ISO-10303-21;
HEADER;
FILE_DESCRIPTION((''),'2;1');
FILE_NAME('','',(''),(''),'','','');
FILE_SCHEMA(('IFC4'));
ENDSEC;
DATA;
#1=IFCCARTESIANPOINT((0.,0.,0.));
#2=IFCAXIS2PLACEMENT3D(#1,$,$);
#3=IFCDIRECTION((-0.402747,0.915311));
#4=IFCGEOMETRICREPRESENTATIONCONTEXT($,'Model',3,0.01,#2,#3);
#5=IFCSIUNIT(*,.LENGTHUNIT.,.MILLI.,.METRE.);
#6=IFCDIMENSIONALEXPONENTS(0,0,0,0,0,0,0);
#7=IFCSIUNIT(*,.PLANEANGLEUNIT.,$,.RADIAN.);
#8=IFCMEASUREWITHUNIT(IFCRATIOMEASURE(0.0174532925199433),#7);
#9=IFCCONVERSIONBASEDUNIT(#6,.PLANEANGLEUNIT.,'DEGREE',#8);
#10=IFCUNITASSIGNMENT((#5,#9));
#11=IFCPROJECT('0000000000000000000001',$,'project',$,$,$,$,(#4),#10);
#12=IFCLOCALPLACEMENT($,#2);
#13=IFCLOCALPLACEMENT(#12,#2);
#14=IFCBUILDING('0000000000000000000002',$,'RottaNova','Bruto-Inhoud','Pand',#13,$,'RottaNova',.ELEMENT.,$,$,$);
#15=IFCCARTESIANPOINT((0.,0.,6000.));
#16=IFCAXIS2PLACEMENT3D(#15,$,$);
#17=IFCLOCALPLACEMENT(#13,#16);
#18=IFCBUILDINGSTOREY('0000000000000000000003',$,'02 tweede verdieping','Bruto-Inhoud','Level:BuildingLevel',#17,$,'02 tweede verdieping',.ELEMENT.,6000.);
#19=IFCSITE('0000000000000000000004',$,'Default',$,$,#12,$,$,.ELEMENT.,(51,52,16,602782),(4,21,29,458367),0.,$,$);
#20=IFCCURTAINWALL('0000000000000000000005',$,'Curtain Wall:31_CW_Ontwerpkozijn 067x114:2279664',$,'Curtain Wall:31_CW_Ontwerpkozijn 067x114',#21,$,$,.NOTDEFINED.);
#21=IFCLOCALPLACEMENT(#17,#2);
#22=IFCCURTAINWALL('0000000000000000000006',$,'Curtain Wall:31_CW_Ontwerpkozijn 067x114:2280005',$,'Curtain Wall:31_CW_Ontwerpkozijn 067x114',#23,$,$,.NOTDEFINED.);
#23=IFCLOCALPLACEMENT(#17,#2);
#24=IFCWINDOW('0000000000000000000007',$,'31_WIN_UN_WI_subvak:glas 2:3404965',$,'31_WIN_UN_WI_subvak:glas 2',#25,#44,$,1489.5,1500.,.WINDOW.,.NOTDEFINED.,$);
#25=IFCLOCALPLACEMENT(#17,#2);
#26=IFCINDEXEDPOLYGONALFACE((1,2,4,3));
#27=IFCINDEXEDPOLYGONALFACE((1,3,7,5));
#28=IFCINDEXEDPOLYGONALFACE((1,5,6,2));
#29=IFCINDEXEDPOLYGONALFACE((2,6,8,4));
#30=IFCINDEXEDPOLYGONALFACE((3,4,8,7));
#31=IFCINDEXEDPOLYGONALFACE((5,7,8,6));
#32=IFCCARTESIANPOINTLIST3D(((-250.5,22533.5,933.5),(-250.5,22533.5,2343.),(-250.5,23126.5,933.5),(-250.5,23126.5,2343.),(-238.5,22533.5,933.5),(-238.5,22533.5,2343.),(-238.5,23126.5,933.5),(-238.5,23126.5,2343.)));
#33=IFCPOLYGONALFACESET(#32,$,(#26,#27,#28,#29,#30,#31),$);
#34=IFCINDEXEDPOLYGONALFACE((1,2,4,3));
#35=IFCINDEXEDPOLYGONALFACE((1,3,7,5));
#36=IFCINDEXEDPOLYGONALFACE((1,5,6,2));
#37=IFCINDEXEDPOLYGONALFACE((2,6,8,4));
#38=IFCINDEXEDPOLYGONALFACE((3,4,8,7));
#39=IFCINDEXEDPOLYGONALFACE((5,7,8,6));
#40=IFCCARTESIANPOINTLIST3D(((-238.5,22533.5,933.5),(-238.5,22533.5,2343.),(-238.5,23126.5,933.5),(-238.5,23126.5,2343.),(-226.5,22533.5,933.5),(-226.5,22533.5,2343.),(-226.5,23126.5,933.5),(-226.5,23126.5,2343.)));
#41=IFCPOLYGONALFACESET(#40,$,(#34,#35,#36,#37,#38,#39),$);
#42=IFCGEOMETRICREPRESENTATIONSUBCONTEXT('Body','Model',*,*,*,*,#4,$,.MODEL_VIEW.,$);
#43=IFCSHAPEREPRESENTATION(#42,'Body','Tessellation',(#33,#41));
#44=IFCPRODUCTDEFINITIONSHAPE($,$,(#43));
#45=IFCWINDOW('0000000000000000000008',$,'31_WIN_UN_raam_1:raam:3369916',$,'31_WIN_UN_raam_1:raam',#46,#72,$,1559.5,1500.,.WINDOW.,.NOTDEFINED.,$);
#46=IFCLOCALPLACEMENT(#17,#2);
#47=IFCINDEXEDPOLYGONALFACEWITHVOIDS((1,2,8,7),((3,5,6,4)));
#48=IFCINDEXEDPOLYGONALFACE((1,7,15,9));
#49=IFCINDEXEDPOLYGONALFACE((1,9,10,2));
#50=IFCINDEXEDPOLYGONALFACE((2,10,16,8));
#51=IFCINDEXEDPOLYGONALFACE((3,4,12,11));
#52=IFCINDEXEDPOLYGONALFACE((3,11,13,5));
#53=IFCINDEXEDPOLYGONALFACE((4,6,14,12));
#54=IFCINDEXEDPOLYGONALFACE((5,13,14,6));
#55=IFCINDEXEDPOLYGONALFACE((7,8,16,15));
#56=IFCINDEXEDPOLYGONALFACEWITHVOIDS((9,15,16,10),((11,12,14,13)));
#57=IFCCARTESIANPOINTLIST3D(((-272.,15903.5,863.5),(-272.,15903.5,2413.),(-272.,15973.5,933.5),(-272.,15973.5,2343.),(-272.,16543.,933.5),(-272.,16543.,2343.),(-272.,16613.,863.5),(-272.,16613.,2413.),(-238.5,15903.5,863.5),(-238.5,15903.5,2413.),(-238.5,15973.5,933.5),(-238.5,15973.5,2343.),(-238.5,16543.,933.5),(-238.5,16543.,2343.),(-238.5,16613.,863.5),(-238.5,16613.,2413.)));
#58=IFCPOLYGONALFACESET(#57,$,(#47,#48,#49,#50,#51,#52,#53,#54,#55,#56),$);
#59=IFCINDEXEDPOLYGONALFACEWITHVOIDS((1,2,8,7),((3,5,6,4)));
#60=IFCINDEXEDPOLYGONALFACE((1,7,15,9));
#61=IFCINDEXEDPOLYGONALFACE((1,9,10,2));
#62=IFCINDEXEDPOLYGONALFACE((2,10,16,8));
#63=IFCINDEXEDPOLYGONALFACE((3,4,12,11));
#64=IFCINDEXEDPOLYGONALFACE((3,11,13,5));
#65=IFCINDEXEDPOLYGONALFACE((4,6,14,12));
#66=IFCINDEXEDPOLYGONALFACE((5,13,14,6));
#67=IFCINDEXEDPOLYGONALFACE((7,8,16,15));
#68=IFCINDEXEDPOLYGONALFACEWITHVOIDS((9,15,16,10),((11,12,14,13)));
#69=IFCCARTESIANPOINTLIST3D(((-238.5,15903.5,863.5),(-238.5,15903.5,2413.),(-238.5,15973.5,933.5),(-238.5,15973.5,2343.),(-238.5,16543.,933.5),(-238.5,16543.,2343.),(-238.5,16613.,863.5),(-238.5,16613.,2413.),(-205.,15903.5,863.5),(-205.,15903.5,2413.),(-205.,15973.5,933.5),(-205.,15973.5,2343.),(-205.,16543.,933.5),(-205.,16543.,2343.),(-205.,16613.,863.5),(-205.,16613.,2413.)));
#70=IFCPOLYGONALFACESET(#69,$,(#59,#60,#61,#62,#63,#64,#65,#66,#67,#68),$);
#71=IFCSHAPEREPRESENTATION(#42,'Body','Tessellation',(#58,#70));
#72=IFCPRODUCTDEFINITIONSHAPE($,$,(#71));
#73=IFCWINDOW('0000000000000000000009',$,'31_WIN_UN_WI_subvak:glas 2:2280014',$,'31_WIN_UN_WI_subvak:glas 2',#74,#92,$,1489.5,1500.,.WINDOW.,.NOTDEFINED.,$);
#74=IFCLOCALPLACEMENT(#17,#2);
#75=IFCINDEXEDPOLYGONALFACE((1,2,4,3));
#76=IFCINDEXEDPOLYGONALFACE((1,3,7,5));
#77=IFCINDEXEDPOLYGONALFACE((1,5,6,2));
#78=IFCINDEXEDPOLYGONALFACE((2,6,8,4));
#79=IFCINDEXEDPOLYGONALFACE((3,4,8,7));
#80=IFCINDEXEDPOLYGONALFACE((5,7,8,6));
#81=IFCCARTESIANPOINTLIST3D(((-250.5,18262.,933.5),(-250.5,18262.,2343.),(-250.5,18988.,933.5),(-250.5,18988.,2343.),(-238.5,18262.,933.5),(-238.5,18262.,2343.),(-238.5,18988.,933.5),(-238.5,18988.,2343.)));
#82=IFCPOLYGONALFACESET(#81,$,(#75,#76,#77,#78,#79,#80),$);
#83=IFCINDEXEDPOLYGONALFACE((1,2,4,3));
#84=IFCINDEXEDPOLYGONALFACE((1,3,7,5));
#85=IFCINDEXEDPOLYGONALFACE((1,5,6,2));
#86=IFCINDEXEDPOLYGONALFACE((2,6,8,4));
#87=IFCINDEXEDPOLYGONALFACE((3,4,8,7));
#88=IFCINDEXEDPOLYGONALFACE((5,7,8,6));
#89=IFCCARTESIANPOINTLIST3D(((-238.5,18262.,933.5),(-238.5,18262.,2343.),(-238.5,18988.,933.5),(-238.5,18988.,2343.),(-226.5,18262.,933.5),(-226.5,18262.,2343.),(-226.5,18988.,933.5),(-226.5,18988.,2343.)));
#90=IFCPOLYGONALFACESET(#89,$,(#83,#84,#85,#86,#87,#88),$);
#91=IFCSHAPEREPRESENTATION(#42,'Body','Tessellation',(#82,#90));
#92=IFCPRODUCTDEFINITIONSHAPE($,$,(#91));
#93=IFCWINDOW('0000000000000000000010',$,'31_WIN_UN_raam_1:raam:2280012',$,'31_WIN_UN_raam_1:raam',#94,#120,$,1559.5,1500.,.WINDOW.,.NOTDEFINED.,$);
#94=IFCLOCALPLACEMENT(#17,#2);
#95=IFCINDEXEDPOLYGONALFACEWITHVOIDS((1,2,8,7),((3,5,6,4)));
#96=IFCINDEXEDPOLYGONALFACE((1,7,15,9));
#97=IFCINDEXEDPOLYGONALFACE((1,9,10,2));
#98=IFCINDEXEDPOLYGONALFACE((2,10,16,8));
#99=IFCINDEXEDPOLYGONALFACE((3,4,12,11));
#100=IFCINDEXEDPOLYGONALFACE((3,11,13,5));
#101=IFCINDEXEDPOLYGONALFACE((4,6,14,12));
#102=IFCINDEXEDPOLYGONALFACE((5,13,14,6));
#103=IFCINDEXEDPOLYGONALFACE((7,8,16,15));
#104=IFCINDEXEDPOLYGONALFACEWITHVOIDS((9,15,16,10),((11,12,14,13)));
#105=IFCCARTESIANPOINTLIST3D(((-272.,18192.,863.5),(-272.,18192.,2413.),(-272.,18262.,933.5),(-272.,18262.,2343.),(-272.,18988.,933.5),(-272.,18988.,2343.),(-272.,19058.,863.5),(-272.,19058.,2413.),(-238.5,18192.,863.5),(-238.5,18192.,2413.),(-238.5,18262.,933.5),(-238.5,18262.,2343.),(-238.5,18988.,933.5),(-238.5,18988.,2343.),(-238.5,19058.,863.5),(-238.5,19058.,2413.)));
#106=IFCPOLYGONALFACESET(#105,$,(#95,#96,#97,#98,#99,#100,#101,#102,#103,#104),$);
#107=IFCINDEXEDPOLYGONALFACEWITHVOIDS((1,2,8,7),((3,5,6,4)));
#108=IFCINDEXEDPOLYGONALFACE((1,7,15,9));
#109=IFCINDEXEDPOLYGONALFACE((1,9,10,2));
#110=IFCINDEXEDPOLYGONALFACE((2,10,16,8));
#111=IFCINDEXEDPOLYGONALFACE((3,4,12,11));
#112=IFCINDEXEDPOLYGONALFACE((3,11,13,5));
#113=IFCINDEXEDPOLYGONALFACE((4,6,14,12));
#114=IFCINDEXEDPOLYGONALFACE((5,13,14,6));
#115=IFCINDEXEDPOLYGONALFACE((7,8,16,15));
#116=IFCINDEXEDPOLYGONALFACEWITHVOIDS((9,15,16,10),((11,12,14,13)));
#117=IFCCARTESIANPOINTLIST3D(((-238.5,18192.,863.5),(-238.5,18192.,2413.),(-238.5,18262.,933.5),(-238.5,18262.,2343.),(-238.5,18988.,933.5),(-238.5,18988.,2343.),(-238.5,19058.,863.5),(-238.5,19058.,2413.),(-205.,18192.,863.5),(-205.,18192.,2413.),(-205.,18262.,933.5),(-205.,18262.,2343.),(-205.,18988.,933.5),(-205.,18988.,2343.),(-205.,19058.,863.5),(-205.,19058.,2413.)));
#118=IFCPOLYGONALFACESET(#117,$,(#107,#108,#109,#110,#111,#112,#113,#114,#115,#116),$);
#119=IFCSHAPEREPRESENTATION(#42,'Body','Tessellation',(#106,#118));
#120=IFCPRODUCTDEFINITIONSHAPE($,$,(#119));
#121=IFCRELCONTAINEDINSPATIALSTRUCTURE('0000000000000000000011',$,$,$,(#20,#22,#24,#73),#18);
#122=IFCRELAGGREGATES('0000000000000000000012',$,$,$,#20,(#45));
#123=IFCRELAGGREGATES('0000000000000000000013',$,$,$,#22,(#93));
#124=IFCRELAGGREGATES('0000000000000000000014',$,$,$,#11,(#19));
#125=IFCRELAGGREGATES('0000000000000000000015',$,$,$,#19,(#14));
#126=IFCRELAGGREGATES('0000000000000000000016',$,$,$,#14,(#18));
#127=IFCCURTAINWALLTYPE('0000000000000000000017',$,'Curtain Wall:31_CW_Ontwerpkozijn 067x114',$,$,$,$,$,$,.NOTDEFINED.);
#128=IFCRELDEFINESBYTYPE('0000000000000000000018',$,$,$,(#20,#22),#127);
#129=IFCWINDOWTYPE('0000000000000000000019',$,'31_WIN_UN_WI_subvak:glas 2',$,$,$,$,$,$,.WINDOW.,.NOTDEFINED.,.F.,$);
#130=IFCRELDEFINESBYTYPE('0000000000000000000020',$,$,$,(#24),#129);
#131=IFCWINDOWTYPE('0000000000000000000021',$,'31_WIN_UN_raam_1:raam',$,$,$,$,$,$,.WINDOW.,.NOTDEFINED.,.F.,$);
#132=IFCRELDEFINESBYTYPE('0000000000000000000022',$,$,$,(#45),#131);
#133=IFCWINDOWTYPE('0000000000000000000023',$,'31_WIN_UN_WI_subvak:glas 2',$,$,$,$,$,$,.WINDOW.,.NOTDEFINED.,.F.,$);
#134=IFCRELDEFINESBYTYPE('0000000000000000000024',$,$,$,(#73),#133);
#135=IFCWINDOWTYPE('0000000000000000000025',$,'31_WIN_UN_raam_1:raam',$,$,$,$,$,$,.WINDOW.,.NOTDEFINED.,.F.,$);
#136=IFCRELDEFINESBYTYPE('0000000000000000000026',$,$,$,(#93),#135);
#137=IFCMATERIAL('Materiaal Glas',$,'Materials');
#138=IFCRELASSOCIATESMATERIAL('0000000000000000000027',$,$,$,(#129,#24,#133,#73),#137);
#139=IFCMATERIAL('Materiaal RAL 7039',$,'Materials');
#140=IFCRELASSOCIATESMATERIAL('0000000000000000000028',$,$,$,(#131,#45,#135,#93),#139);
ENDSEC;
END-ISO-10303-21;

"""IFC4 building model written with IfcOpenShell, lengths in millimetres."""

from ifc_helpers import new_model, entity, si_unit, converted_unit, direction, frame, frame_2d, origin, origin_2d_with_axis, place, context, subcontext, project, spatial, polyline, rectangle, outline, extrude, source, transform, mapped, material, type_object, type_shapes, element, aggregate, save


model = new_model("IFC4")

# Units and contexts
model_context = context("Model", 3, precision=0.01, world=origin(), true_north=direction((-0.402747, 0.915311)))
body_context = subcontext(model_context, "Body", "Model", "MODEL_VIEW")
ifc_project = project(units=[si_unit("LENGTHUNIT", "METRE", prefix="MILLI"), converted_unit("PLANEANGLEUNIT", "DEGREE", entity("IfcRatioMeasure", 0.0174532925199433), si_unit("PLANEANGLEUNIT", "RADIAN"), dimensions=[0, 0, 0, 0, 0, 0, 0])], contexts=[model_context])

# Site, building, storey
site_placement = place(None, origin())
site = spatial("IfcSite", under=ifc_project, at=site_placement, Name="Default", CompositionType="ELEMENT", RefLatitude=(51, 52, 16, 602782), RefLongitude=(4, 21, 29, 458367), RefElevation=0.0)
building_placement = place(site_placement, origin())
building = spatial("IfcBuilding", under=site, at=building_placement, Name="RottaNova", Description="Bruto-Inhoud", ObjectType="Pand", LongName="RottaNova", CompositionType="ELEMENT")
storey_placement = place(building_placement, frame((0.0, 0.0, 6000.0)))
storey = spatial("IfcBuildingStorey", under=building, at=storey_placement, Name="02 tweede verdieping", Description="Bruto-Inhoud", ObjectType="Level:BuildingLevel", LongName="02 tweede verdieping", CompositionType="ELEMENT", Elevation=6000.0)

# Curtain walls
curtain_wall_type = type_object("IfcCurtainWallType", Name="Curtain Wall:31_CW_Ontwerpkozijn 067x114", PredefinedType="NOTDEFINED")
curtain_wall_1_placement = place(storey_placement, frame((0.0, 0.0, -6000.0)))
curtain_wall_1 = element("IfcCurtainWall", 1, at=curtain_wall_1_placement, inside=storey, type_object=curtain_wall_type, Name="Curtain Wall:31_CW_Ontwerpkozijn 067x114:2279664", ObjectType="Curtain Wall:31_CW_Ontwerpkozijn 067x114", PredefinedType="NOTDEFINED")
curtain_wall_2_placement = place(storey_placement, frame((0.0, 0.0, -6000.0)))
curtain_wall_2 = element("IfcCurtainWall", 2, at=curtain_wall_2_placement, inside=storey, type_object=curtain_wall_type, Name="Curtain Wall:31_CW_Ontwerpkozijn 067x114:2280005", ObjectType="Curtain Wall:31_CW_Ontwerpkozijn 067x114", PredefinedType="NOTDEFINED")

# Shared definitions
ifc_material_1 = material(Name="Materiaal Glas", Category="Materials")

# Window
window_type_1 = type_object("IfcWindowType", Name="31_WIN_UN_WI_subvak:glas 2", ParameterTakesPrecedence=False, PartitioningType="NOTDEFINED", PredefinedType="WINDOW", material=ifc_material_1)
shared_shape_1 = source(origin(), body_context, "Body", "SweptSolid", [
    extrude(rectangle(XDim=593.0, YDim=12.0, at=origin_2d_with_axis()), frame((0.0, -6.0, 0.0)), (0.0, 0.0, 1.0), 1409.5),
    extrude(rectangle(XDim=593.0, YDim=12.0, at=origin_2d_with_axis()), frame((0.0, 6.0, 0.0)), (0.0, 0.0, 1.0), 1409.5),
])
type_shapes(window_type_1, [shared_shape_1])
window_1_placement = place(storey_placement, frame((-238.5, 22830.0, 933.5), z_axis=(0.0, 0.0, 1.0), x_axis=(0.0, -1.0, 0.0)))
element("IfcWindow", 3, at=window_1_placement, inside=storey, type_object=window_type_1, material=ifc_material_1, Name="31_WIN_UN_WI_subvak:glas 2:3404965", ObjectType="31_WIN_UN_WI_subvak:glas 2", OverallHeight=1489.5, OverallWidth=1500.0, PartitioningType="NOTDEFINED", PredefinedType="WINDOW", context=body_context, shape_type="MappedRepresentation", body=[
    mapped(shared_shape_1, transform((0.0, 0.0, 0.0), scale=1.0)),
])

# Windows
ifc_material_2 = material(Name="Materiaal RAL 7039", Category="Materials")
window_type_2 = type_object("IfcWindowType", Name="31_WIN_UN_raam_1:raam", ParameterTakesPrecedence=False, PartitioningType="NOTDEFINED", PredefinedType="WINDOW", material=ifc_material_2)
shared_shape_2 = source(origin(), body_context, "Body", "SweptSolid", [
    extrude(outline(polyline([(-354.7, -774.7), (354.7, -774.7), (354.7, 774.7), (-354.7, 774.7), (-354.7, -774.7)]), holes=[polyline([(-284.7, 704.7), (284.7, 704.7), (284.7, -704.8), (-284.7, -704.8), (-284.7, 704.7)])]), frame((0.0, 92.0, 774.8), z_axis=(0.0, -1.0, 0.0), x_axis=(-1.0, 0.0, 0.0)), (0.0, 0.0, 1.0), 33.5),
    extrude(outline(polyline([(-354.7, -774.7), (354.7, -774.7), (354.7, 774.7), (-354.7, 774.7), (-354.7, -774.7)]), holes=[polyline([(-284.7, 704.7), (284.7, 704.7), (284.7, -704.8), (-284.7, -704.8), (-284.7, 704.7)])]), frame((0.0, 58.5, 774.8), z_axis=(0.0, -1.0, 0.0), x_axis=(-1.0, 0.0, 0.0)), (0.0, 0.0, 1.0), 33.5),
])
type_shapes(window_type_2, [shared_shape_2])
window_2_placement = place(curtain_wall_1_placement, frame((-180.0, 16258.3, 6863.5), z_axis=(0.0, 0.0, 1.0), x_axis=(0.0, 1.0, 0.0)))
window_2 = element("IfcWindow", 4, at=window_2_placement, type_object=window_type_2, material=ifc_material_2, Name="31_WIN_UN_raam_1:raam:3369916", ObjectType="31_WIN_UN_raam_1:raam", OverallHeight=1559.5, OverallWidth=1500.0, PartitioningType="NOTDEFINED", PredefinedType="WINDOW", context=body_context, shape_type="MappedRepresentation", body=[
    mapped(shared_shape_2, transform((0.0, 0.0, 0.0), scale=1.0)),
])
aggregate(curtain_wall_1, [window_2])
window_type_3 = type_object("IfcWindowType", Name="31_WIN_UN_WI_subvak:glas 2", ParameterTakesPrecedence=False, PartitioningType="NOTDEFINED", PredefinedType="WINDOW", material=ifc_material_1)
shared_shape_3 = source(origin(), body_context, "Body", "SweptSolid", [
    extrude(rectangle(XDim=12.0, YDim=726.0, at=frame_2d((0.0, 0.0), x_axis=(1.0, 0.0))), frame((0.0, 6.0, 0.0), z_axis=(0.0, 0.0, 1.0), x_axis=(0.0, -1.0, 0.0)), (0.0, 0.0, 1.0), 1409.5),
    extrude(rectangle(XDim=12.0, YDim=726.0, at=frame_2d((0.0, 0.0), x_axis=(1.0, 0.0))), frame((0.0, -6.0, 0.0), z_axis=(0.0, 0.0, 1.0), x_axis=(0.0, -1.0, 0.0)), (0.0, 0.0, 1.0), 1409.5),
])
type_shapes(window_type_3, [shared_shape_3])
window_3_placement = place(storey_placement, frame((-238.5, 18625.0, 933.5), z_axis=(0.0, 0.0, 1.0), x_axis=(0.0, 1.0, 0.0)))
element("IfcWindow", 5, at=window_3_placement, inside=storey, type_object=window_type_3, material=ifc_material_1, Name="31_WIN_UN_WI_subvak:glas 2:2280014", ObjectType="31_WIN_UN_WI_subvak:glas 2", OverallHeight=1489.5, OverallWidth=1500.0, PartitioningType="NOTDEFINED", PredefinedType="WINDOW", context=body_context, shape_type="MappedRepresentation", body=[
    mapped(shared_shape_3, transform((0.0, 0.0, 0.0), scale=1.0)),
])
window_type_4 = type_object("IfcWindowType", Name="31_WIN_UN_raam_1:raam", ParameterTakesPrecedence=False, PartitioningType="NOTDEFINED", PredefinedType="WINDOW", material=ifc_material_2)
shared_shape_4 = source(origin(), body_context, "Body", "SweptSolid", [
    extrude(outline(polyline([(-433.0, -774.7), (433.0, -774.7), (433.0, 774.7), (-433.0, 774.7), (-433.0, -774.7)]), holes=[polyline([(-363.0, 704.7), (363.0, 704.7), (363.0, -704.8), (-363.0, -704.8), (-363.0, 704.7)])]), frame((0.0, 58.5, 774.8), z_axis=(0.0, 1.0, 0.0), x_axis=(1.0, 0.0, 0.0)), (0.0, 0.0, 1.0), 33.5),
    extrude(outline(polyline([(-433.0, -774.7), (433.0, -774.7), (433.0, 774.7), (-433.0, 774.7), (-433.0, -774.7)]), holes=[polyline([(-363.0, 704.7), (363.0, 704.7), (363.0, -704.8), (-363.0, -704.8), (-363.0, 704.7)])]), frame((0.0, 25.0, 774.8), z_axis=(0.0, 1.0, 0.0), x_axis=(1.0, 0.0, 0.0)), (0.0, 0.0, 1.0), 33.5),
])
type_shapes(window_type_4, [shared_shape_4])
window_4_placement = place(curtain_wall_2_placement, frame((-180.0, 18625.0, 6863.5), z_axis=(0.0, 0.0, 1.0), x_axis=(0.0, 1.0, 0.0)))
window_4 = element("IfcWindow", 6, at=window_4_placement, type_object=window_type_4, material=ifc_material_2, Name="31_WIN_UN_raam_1:raam:2280012", ObjectType="31_WIN_UN_raam_1:raam", OverallHeight=1559.5, OverallWidth=1500.0, PartitioningType="NOTDEFINED", PredefinedType="WINDOW", context=body_context, shape_type="MappedRepresentation", body=[
    mapped(shared_shape_4, transform((0.0, 0.0, 0.0), scale=1.0)),
])
aggregate(curtain_wall_2, [window_4])

save(model, "model.ifc")
